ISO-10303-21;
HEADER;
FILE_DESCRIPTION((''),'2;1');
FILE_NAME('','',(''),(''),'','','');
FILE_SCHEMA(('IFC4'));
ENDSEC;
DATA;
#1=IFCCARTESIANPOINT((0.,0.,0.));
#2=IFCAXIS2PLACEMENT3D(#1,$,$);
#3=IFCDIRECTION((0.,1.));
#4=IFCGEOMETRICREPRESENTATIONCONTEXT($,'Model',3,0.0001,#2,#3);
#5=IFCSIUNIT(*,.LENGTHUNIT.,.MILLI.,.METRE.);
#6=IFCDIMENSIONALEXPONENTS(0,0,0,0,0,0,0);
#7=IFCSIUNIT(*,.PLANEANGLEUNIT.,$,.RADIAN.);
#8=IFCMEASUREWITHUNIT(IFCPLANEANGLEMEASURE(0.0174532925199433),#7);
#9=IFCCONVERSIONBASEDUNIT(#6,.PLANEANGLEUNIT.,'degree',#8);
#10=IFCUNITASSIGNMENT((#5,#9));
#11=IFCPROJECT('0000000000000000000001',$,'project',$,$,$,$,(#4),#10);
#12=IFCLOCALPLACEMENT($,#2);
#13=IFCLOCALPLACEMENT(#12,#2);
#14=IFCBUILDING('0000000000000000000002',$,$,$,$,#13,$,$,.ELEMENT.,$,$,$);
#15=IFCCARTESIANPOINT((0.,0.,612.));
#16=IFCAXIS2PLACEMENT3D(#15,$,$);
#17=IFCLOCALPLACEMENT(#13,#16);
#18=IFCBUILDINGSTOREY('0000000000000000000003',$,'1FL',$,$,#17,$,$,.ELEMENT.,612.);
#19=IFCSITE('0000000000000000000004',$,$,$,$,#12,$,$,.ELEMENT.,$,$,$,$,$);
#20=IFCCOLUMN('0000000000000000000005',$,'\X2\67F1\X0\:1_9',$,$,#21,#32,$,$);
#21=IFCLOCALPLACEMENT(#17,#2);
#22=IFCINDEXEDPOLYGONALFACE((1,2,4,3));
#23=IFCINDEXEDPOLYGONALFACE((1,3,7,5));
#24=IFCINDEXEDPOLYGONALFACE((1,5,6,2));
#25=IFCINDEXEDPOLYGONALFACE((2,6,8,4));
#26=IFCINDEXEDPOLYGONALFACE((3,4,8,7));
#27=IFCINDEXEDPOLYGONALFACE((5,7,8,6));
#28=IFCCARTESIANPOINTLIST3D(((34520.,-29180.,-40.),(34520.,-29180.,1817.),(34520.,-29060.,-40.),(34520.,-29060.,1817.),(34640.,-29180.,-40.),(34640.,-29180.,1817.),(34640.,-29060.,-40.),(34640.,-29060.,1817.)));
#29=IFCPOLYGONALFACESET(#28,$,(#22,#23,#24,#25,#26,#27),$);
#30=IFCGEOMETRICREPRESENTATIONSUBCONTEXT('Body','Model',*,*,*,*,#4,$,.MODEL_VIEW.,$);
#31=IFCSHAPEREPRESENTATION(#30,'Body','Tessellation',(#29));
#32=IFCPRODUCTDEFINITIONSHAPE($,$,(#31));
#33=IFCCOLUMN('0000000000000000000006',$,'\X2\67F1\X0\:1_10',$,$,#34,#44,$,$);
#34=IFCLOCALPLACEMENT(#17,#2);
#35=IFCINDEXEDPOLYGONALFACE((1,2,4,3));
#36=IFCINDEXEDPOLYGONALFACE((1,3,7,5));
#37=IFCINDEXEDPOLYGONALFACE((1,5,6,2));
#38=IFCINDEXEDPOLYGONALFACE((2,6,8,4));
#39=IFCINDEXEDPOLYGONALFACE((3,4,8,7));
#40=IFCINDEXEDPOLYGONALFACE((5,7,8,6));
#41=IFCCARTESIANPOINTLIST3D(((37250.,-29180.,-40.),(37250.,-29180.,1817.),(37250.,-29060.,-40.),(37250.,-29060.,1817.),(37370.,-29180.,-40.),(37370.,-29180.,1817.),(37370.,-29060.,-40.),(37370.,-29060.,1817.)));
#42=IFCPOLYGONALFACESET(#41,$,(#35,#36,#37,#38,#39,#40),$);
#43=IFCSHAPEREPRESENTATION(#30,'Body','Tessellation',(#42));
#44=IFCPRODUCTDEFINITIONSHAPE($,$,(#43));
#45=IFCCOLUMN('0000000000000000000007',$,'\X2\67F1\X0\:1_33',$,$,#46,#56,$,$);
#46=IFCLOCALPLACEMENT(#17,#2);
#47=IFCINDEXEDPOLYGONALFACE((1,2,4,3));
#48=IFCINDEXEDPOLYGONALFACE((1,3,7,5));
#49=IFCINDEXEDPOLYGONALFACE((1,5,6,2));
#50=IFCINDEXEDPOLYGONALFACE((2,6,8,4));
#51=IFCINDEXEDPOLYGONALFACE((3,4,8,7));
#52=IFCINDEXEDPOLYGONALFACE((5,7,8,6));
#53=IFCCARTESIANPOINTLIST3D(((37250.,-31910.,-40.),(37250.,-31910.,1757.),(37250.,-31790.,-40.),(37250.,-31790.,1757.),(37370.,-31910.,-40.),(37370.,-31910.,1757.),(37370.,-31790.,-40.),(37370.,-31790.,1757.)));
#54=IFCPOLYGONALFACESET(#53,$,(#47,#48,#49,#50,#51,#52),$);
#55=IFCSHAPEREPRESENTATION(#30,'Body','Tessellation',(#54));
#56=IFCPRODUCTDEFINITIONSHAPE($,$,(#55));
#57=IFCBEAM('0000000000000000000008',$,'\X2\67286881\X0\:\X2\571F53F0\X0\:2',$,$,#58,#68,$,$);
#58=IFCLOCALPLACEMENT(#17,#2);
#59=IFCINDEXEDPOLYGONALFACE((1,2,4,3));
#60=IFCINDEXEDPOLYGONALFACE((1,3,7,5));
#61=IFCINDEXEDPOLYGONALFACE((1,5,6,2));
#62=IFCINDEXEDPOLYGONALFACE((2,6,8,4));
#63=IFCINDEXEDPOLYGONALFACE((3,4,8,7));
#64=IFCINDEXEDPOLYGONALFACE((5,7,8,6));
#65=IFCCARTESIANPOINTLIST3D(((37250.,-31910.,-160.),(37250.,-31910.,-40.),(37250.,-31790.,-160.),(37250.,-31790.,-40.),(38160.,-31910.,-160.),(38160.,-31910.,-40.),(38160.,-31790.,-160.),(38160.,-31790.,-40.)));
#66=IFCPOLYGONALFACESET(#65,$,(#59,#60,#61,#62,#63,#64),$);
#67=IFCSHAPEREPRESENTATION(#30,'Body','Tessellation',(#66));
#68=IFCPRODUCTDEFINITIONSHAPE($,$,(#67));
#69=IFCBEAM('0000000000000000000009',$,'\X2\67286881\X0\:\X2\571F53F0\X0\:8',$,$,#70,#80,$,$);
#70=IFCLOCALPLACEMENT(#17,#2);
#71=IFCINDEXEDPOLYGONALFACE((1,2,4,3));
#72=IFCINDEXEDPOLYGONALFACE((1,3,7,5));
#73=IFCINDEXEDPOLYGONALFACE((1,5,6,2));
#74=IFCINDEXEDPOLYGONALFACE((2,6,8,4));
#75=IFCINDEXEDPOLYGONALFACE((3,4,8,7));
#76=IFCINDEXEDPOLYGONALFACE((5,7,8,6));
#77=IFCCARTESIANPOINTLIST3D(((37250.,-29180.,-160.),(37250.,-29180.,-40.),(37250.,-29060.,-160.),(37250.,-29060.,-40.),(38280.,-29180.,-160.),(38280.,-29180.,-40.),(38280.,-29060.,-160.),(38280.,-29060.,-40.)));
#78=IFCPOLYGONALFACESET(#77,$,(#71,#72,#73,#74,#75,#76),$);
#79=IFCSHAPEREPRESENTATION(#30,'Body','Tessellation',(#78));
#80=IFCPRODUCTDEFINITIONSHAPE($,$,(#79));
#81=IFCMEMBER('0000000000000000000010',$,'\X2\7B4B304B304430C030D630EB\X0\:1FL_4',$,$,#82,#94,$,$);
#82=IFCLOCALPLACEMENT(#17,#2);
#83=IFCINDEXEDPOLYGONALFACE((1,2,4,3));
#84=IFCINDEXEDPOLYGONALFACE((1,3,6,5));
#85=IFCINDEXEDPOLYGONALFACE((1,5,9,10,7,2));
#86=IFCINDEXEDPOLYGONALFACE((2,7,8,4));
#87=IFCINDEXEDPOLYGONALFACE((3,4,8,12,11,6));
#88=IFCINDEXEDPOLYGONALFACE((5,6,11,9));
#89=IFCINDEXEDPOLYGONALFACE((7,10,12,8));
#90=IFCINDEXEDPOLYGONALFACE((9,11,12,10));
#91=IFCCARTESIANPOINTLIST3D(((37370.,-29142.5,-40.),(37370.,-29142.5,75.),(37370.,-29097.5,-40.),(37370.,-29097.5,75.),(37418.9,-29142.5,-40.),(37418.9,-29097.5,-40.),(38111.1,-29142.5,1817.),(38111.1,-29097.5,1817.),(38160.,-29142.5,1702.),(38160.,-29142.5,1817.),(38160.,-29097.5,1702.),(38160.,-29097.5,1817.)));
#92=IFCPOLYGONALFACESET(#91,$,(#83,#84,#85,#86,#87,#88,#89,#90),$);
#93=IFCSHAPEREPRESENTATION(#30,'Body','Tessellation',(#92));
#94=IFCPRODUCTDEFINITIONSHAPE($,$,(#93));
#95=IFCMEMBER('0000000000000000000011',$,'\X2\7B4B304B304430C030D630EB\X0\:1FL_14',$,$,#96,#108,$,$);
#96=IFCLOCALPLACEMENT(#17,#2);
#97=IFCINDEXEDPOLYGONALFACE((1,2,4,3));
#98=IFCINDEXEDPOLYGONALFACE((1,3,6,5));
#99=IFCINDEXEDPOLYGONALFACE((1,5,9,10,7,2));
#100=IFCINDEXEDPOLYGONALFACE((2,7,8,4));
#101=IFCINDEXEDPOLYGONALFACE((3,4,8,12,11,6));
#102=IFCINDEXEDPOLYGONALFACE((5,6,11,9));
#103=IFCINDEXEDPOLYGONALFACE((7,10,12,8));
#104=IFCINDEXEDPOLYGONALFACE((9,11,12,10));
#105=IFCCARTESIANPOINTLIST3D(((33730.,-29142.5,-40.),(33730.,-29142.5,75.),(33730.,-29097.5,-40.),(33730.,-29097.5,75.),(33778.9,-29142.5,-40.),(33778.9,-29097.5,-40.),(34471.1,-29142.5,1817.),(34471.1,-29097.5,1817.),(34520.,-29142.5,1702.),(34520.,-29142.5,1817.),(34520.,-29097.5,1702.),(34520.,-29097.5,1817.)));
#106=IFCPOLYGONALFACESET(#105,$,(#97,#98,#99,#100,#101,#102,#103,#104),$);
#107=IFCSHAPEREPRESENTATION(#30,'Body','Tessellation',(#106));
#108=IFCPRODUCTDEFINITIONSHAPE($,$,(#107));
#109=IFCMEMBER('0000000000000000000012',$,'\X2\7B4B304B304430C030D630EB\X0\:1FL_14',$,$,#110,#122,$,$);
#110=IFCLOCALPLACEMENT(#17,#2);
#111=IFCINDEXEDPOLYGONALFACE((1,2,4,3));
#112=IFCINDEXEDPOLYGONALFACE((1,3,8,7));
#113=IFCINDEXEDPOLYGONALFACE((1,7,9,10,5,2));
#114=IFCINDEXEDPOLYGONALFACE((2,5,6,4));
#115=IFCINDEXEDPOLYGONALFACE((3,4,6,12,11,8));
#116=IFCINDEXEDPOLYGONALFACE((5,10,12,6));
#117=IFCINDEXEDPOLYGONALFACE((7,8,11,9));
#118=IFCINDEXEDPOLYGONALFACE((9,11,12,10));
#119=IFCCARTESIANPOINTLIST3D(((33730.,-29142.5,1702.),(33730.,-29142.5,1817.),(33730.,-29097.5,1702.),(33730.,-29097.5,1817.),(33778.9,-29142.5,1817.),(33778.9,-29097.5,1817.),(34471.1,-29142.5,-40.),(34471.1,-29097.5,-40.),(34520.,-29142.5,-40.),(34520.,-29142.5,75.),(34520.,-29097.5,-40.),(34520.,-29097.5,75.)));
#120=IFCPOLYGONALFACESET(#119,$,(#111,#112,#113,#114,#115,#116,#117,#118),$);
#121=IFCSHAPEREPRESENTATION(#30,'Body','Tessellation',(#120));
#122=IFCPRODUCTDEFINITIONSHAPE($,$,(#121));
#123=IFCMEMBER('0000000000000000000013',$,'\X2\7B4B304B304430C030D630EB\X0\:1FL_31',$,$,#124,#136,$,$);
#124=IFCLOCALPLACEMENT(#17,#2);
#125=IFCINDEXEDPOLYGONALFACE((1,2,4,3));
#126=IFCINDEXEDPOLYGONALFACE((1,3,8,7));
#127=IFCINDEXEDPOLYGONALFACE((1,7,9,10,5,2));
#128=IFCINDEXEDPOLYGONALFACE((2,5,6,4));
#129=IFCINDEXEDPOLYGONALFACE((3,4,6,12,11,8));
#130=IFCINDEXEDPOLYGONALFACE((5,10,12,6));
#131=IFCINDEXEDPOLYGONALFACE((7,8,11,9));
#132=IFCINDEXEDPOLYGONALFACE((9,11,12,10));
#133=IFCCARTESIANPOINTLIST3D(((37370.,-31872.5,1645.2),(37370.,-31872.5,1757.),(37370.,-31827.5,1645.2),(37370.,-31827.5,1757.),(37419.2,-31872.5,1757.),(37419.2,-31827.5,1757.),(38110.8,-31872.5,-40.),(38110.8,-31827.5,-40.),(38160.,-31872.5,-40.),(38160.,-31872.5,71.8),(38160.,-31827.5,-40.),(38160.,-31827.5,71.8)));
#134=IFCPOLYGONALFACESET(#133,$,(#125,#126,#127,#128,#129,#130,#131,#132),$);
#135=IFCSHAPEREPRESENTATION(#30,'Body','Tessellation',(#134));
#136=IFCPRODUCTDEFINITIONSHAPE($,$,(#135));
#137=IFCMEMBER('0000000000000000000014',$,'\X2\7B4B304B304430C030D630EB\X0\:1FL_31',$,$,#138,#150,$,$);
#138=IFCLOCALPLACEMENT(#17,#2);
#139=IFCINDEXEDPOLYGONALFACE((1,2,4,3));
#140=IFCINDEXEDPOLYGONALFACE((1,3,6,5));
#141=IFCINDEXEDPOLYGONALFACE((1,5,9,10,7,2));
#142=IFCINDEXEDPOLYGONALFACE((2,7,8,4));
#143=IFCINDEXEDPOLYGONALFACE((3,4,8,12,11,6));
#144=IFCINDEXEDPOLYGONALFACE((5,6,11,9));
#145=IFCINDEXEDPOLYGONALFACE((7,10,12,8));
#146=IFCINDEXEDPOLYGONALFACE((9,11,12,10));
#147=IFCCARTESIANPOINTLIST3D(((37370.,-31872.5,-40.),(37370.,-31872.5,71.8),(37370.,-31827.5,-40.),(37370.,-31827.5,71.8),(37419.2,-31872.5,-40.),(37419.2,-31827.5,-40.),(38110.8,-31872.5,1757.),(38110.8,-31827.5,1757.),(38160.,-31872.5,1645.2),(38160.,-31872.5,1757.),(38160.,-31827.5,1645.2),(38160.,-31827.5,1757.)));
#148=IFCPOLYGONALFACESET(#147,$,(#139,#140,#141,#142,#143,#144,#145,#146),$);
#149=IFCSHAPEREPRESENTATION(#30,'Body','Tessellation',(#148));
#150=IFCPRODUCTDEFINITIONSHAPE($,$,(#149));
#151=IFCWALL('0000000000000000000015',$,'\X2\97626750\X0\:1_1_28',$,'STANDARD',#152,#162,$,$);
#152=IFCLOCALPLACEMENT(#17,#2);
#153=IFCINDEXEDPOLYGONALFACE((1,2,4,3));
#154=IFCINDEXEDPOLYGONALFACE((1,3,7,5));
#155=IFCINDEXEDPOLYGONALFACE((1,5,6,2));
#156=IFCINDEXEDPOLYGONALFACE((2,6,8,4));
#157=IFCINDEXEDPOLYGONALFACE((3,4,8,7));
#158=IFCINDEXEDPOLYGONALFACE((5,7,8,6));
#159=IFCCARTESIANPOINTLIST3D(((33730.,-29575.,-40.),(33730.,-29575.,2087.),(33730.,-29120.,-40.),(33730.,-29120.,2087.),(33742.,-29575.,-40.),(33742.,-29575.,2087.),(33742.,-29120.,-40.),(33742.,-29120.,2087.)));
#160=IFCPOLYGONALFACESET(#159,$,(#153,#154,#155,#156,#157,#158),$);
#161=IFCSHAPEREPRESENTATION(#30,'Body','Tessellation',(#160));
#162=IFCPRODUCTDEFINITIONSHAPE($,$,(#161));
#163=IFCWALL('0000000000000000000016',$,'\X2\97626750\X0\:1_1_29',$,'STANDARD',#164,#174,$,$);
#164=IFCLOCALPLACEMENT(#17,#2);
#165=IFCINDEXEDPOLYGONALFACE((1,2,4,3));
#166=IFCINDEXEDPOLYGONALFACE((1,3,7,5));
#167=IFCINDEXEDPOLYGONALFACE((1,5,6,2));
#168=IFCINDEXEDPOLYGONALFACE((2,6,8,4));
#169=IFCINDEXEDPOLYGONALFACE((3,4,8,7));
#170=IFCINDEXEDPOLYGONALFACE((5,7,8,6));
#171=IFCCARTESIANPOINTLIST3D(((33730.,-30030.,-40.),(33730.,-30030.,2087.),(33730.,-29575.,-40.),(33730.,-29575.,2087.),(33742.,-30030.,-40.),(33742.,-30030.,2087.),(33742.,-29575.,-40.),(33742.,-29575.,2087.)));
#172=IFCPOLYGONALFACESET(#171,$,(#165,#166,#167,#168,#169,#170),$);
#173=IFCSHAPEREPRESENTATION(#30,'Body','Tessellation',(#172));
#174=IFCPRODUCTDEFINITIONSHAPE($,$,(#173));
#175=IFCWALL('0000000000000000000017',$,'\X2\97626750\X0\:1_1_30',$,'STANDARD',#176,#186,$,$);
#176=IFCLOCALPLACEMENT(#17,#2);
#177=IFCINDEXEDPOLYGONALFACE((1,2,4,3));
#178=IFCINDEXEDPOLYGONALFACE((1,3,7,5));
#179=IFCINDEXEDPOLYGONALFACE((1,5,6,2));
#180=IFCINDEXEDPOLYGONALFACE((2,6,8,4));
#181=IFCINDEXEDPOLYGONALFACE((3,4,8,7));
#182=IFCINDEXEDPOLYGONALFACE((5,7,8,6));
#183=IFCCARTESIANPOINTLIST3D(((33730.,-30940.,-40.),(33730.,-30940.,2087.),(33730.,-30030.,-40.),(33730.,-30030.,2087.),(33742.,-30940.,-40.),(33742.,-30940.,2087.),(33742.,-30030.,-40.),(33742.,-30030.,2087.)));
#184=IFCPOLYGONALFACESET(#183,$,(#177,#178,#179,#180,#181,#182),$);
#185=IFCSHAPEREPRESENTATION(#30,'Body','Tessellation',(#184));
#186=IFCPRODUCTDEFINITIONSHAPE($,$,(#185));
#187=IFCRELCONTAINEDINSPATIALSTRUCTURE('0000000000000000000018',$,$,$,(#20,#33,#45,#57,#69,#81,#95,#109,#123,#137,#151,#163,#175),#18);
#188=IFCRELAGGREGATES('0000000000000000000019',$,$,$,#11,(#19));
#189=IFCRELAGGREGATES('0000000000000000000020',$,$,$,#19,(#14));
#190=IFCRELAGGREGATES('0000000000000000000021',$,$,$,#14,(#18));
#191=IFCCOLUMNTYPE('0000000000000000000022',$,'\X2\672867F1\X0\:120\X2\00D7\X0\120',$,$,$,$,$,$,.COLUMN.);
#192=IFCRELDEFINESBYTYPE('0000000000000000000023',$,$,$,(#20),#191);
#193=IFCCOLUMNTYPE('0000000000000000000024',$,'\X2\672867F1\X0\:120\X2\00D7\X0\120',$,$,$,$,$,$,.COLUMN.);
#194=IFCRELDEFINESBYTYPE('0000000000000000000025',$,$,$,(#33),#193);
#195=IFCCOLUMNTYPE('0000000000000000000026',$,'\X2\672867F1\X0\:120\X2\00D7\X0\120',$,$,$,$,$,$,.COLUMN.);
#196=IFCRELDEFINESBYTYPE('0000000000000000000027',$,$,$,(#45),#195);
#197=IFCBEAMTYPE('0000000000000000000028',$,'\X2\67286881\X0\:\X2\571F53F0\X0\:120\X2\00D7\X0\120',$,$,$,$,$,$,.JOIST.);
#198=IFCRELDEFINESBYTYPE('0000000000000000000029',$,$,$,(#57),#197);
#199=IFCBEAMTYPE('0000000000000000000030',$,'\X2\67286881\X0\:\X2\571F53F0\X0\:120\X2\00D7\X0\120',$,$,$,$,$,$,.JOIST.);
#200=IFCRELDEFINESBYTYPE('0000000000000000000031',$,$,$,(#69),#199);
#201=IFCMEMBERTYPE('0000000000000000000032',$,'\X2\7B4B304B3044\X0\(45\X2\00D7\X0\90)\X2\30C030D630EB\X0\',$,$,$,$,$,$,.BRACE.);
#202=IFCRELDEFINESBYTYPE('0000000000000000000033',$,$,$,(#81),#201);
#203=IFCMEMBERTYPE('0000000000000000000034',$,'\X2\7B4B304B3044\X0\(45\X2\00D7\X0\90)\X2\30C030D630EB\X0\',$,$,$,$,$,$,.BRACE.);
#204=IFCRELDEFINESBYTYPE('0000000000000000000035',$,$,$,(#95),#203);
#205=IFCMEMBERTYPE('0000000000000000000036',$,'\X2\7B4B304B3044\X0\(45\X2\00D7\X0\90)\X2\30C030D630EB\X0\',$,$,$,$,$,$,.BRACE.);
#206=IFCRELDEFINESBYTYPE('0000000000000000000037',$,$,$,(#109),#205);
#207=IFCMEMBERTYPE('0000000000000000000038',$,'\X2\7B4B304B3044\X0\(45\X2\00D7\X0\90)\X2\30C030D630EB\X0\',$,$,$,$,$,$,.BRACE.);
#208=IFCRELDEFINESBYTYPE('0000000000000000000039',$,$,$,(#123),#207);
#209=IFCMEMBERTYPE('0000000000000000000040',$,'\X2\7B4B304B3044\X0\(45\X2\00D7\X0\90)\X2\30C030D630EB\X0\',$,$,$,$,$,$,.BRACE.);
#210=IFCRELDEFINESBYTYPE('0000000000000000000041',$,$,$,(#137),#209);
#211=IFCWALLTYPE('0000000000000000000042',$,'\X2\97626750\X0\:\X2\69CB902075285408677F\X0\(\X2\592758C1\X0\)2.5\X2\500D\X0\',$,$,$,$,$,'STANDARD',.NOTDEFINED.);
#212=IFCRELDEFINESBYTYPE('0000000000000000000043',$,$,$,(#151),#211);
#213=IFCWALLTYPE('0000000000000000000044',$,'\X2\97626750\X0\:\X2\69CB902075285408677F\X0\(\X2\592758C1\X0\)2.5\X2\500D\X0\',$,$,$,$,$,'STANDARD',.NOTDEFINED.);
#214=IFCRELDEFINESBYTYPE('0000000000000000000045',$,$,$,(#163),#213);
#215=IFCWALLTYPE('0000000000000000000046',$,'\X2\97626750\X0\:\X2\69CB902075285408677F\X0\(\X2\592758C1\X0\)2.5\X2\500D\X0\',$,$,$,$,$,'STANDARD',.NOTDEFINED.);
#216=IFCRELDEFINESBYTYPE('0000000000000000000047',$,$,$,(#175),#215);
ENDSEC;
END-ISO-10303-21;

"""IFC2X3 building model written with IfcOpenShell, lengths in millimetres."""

from ifc_helpers import new_model, entity, si_unit, converted_unit, direction, frame, origin, origin_with_axes, origin_2d, place, context, subcontext, project, spatial, polyline, rectangle, outline, extrude, type_object, element, save


model = new_model("IFC2X3")

# Units and contexts
model_context = context("Model", 3, precision=0.0001, world=origin(), true_north=direction((0.0, 1.0)))
body_context = subcontext(model_context, "Body", "Model", "MODEL_VIEW")
ifc_project = project(units=[si_unit("LENGTHUNIT", "METRE", prefix="MILLI"), converted_unit("PLANEANGLEUNIT", "degree", entity("IfcPlaneAngleMeasure", 0.0174532925199433), si_unit("PLANEANGLEUNIT", "RADIAN"), dimensions=[0, 0, 0, 0, 0, 0, 0])], contexts=[model_context])

# Site, building, storey
site_placement = place(None, origin())
site = spatial("IfcSite", under=ifc_project, at=site_placement, CompositionType="ELEMENT")
building_placement = place(site_placement, origin())
building = spatial("IfcBuilding", under=site, at=building_placement, CompositionType="ELEMENT")
storey_placement = place(building_placement, frame((0.0, 0.0, 612.0)))
storey = spatial("IfcBuildingStorey", under=building, at=storey_placement, Name="1FL", CompositionType="ELEMENT", Elevation=612.0)

# Columns
column_type_1 = type_object("IfcColumnType", Name="木柱:120×120", PredefinedType="COLUMN")
column_1_placement = place(storey_placement, frame((34580.0, -29120.0, -40.0)))
element("IfcColumn", 1, at=column_1_placement, inside=storey, type_object=column_type_1, Name="柱:1_9", context=body_context, shape_type="SweptSolid", body=[
    extrude(rectangle(XDim=120.0, YDim=120.0, at=origin_2d()), origin_with_axes(), (0.0, 0.0, 1.0), 1857.0),
])
column_type_2 = type_object("IfcColumnType", Name="木柱:120×120", PredefinedType="COLUMN")
column_2_placement = place(storey_placement, frame((37310.0, -29120.0, -40.0)))
element("IfcColumn", 2, at=column_2_placement, inside=storey, type_object=column_type_2, Name="柱:1_10", context=body_context, shape_type="SweptSolid", body=[
    extrude(rectangle(XDim=120.0, YDim=120.0, at=origin_2d()), origin_with_axes(), (0.0, 0.0, 1.0), 1857.0),
])
column_type_3 = type_object("IfcColumnType", Name="木柱:120×120", PredefinedType="COLUMN")
column_3_placement = place(storey_placement, frame((37310.0, -31850.0, -40.0)))
element("IfcColumn", 3, at=column_3_placement, inside=storey, type_object=column_type_3, Name="柱:1_33", context=body_context, shape_type="SweptSolid", body=[
    extrude(rectangle(XDim=120.0, YDim=120.0, at=origin_2d()), origin_with_axes(), (0.0, 0.0, 1.0), 1797.0),
])

# Beams
beam_type_1 = type_object("IfcBeamType", Name="木梁:土台:120×120", PredefinedType="JOIST")
beam_1_placement = place(storey_placement, frame((37250.0, -31850.0, -100.0), z_axis=(1.0, 0.0, 0.0), x_axis=(0.0, 1.0, 0.0)))
element("IfcBeam", 4, at=beam_1_placement, inside=storey, type_object=beam_type_1, Name="木梁:土台:2", context=body_context, shape_type="SweptSolid", body=[
    extrude(rectangle(XDim=120.0, YDim=120.0, at=origin_2d()), origin_with_axes(), (0.0, 0.0, 1.0), 910.0),
])
beam_type_2 = type_object("IfcBeamType", Name="木梁:土台:120×120", PredefinedType="JOIST")
beam_2_placement = place(storey_placement, frame((37250.0, -29120.0, -100.0), z_axis=(1.0, 0.0, 0.0), x_axis=(0.0, 1.0, 0.0)))
element("IfcBeam", 5, at=beam_2_placement, inside=storey, type_object=beam_type_2, Name="木梁:土台:8", context=body_context, shape_type="SweptSolid", body=[
    extrude(rectangle(XDim=120.0, YDim=120.0, at=origin_2d()), origin_with_axes(), (0.0, 0.0, 1.0), 1030.0),
])

# Members
member_type_1 = type_object("IfcMemberType", Name="筋かい(45×90)ダブル", PredefinedType="BRACE")
member_1_placement = place(storey_placement, frame((37370.0, -29120.0, -40.0), z_axis=(0.391466, 0.0, 0.920193), x_axis=(-0.920193, 0.0, 0.391466)))
element("IfcMember", 6, at=member_1_placement, inside=storey, type_object=member_type_1, Name="筋かいダブル:1FL_4", context=body_context, shape_type="SweptSolid", body=[
    extrude(outline(polyline([(0.0, 0.0), (19.1, -45.0), (1912.3, -45.0), (2018.1, 0.0), (1998.9, 45.0), (105.8, 45.0), (0.0, 0.0)])), frame((0.0, -22.5, 0.0), z_axis=(0.0, 1.0, 0.0), x_axis=(0.0, 0.0, 1.0)), (0.0, 0.0, 1.0), 45.0),
])
member_type_2 = type_object("IfcMemberType", Name="筋かい(45×90)ダブル", PredefinedType="BRACE")
member_2_placement = place(storey_placement, frame((33730.0, -29120.0, -40.0), z_axis=(0.391466, 0.0, 0.920193), x_axis=(-0.920193, 0.0, 0.391466)))
element("IfcMember", 7, at=member_2_placement, inside=storey, type_object=member_type_2, Name="筋かいダブル:1FL_14", context=body_context, shape_type="SweptSolid", body=[
    extrude(outline(polyline([(0.0, 0.0), (19.1, -45.0), (1912.3, -45.0), (2018.1, 0.0), (1998.9, 45.0), (105.8, 45.0), (0.0, 0.0)])), frame((0.0, -22.5, 0.0), z_axis=(0.0, 1.0, 0.0), x_axis=(0.0, 0.0, 1.0)), (0.0, 0.0, 1.0), 45.0),
])
member_type_3 = type_object("IfcMemberType", Name="筋かい(45×90)ダブル", PredefinedType="BRACE")
member_3_placement = place(storey_placement, frame((34520.0, -29120.0, -40.0), z_axis=(-0.391466, 0.0, 0.920193), x_axis=(0.920193, 0.0, 0.391466)))
element("IfcMember", 8, at=member_3_placement, inside=storey, type_object=member_type_3, Name="筋かいダブル:1FL_14", context=body_context, shape_type="SweptSolid", body=[
    extrude(outline(polyline([(0.0, 0.0), (19.1, -45.0), (1912.3, -45.0), (2018.1, 0.0), (1998.9, 45.0), (105.8, 45.0), (0.0, 0.0)])), frame((0.0, -22.5, 0.0), z_axis=(0.0, 1.0, 0.0), x_axis=(0.0, 0.0, 1.0)), (0.0, 0.0, 1.0), 45.0),
])
member_type_4 = type_object("IfcMemberType", Name="筋かい(45×90)ダブル", PredefinedType="BRACE")
member_4_placement = place(storey_placement, frame((38160.0, -31850.0, -40.0), z_axis=(-0.402448, 0.0, 0.915443), x_axis=(0.915443, 0.0, 0.402448)))
element("IfcMember", 9, at=member_4_placement, inside=storey, type_object=member_type_4, Name="筋かいダブル:1FL_31", context=body_context, shape_type="SweptSolid", body=[
    extrude(outline(polyline([(0.0, 0.0), (19.8, -45.0), (1860.6, -45.0), (1963.0, 0.0), (1943.2, 45.0), (102.4, 45.0), (0.0, 0.0)])), frame((0.0, -22.5, 0.0), z_axis=(0.0, 1.0, 0.0), x_axis=(0.0, 0.0, 1.0)), (0.0, 0.0, 1.0), 45.0),
])
member_type_5 = type_object("IfcMemberType", Name="筋かい(45×90)ダブル", PredefinedType="BRACE")
member_5_placement = place(storey_placement, frame((37370.0, -31850.0, -40.0), z_axis=(0.402448, 0.0, 0.915443), x_axis=(-0.915443, 0.0, 0.402448)))
element("IfcMember", 10, at=member_5_placement, inside=storey, type_object=member_type_5, Name="筋かいダブル:1FL_31", context=body_context, shape_type="SweptSolid", body=[
    extrude(outline(polyline([(0.0, 0.0), (19.8, -45.0), (1860.6, -45.0), (1963.0, 0.0), (1943.2, 45.0), (102.4, 45.0), (0.0, 0.0)])), frame((0.0, -22.5, 0.0), z_axis=(0.0, 1.0, 0.0), x_axis=(0.0, 0.0, 1.0)), (0.0, 0.0, 1.0), 45.0),
])

# Walls
wall_type_1 = type_object("IfcWallType", Name="面材:構造用合板(大壁)2.5倍", ElementType="STANDARD", PredefinedType="NOTDEFINED")
wall_1_placement = place(storey_placement, frame((33742.0, -29347.5, -40.0), z_axis=(-1.0, 0.0, 0.0), x_axis=(0.0, -1.0, 0.0)))
element("IfcWall", 11, at=wall_1_placement, inside=storey, type_object=wall_type_1, Name="面材:1_1_28", ObjectType="STANDARD", context=body_context, shape_type="SweptSolid", body=[
    extrude(outline(polyline([(227.5, 0.0, 0.0), (-227.5, 0.0, 0.0), (-227.5, 2127.0, 0.0), (227.5, 2127.0, 0.0), (227.5, 0.0, 0.0)])), origin_with_axes(), (0.0, 0.0, 1.0), 12.0),
])
wall_type_2 = type_object("IfcWallType", Name="面材:構造用合板(大壁)2.5倍", ElementType="STANDARD", PredefinedType="NOTDEFINED")
wall_2_placement = place(storey_placement, frame((33742.0, -29802.5, -40.0), z_axis=(-1.0, 0.0, 0.0), x_axis=(0.0, -1.0, 0.0)))
element("IfcWall", 12, at=wall_2_placement, inside=storey, type_object=wall_type_2, Name="面材:1_1_29", ObjectType="STANDARD", context=body_context, shape_type="SweptSolid", body=[
    extrude(outline(polyline([(227.5, 0.0, 0.0), (-227.5, 0.0, 0.0), (-227.5, 2127.0, 0.0), (227.5, 2127.0, 0.0), (227.5, 0.0, 0.0)])), origin_with_axes(), (0.0, 0.0, 1.0), 12.0),
])
wall_type_3 = type_object("IfcWallType", Name="面材:構造用合板(大壁)2.5倍", ElementType="STANDARD", PredefinedType="NOTDEFINED")
wall_3_placement = place(storey_placement, frame((33742.0, -30485.0, -40.0), z_axis=(-1.0, 0.0, 0.0), x_axis=(0.0, -1.0, 0.0)))
element("IfcWall", 13, at=wall_3_placement, inside=storey, type_object=wall_type_3, Name="面材:1_1_30", ObjectType="STANDARD", context=body_context, shape_type="SweptSolid", body=[
    extrude(outline(polyline([(455.0, 0.0, 0.0), (-455.0, 0.0, 0.0), (-455.0, 2127.0, 0.0), (455.0, 2127.0, 0.0), (455.0, 0.0, 0.0)])), origin_with_axes(), (0.0, 0.0, 1.0), 12.0),
])

save(model, "model.ifc")
